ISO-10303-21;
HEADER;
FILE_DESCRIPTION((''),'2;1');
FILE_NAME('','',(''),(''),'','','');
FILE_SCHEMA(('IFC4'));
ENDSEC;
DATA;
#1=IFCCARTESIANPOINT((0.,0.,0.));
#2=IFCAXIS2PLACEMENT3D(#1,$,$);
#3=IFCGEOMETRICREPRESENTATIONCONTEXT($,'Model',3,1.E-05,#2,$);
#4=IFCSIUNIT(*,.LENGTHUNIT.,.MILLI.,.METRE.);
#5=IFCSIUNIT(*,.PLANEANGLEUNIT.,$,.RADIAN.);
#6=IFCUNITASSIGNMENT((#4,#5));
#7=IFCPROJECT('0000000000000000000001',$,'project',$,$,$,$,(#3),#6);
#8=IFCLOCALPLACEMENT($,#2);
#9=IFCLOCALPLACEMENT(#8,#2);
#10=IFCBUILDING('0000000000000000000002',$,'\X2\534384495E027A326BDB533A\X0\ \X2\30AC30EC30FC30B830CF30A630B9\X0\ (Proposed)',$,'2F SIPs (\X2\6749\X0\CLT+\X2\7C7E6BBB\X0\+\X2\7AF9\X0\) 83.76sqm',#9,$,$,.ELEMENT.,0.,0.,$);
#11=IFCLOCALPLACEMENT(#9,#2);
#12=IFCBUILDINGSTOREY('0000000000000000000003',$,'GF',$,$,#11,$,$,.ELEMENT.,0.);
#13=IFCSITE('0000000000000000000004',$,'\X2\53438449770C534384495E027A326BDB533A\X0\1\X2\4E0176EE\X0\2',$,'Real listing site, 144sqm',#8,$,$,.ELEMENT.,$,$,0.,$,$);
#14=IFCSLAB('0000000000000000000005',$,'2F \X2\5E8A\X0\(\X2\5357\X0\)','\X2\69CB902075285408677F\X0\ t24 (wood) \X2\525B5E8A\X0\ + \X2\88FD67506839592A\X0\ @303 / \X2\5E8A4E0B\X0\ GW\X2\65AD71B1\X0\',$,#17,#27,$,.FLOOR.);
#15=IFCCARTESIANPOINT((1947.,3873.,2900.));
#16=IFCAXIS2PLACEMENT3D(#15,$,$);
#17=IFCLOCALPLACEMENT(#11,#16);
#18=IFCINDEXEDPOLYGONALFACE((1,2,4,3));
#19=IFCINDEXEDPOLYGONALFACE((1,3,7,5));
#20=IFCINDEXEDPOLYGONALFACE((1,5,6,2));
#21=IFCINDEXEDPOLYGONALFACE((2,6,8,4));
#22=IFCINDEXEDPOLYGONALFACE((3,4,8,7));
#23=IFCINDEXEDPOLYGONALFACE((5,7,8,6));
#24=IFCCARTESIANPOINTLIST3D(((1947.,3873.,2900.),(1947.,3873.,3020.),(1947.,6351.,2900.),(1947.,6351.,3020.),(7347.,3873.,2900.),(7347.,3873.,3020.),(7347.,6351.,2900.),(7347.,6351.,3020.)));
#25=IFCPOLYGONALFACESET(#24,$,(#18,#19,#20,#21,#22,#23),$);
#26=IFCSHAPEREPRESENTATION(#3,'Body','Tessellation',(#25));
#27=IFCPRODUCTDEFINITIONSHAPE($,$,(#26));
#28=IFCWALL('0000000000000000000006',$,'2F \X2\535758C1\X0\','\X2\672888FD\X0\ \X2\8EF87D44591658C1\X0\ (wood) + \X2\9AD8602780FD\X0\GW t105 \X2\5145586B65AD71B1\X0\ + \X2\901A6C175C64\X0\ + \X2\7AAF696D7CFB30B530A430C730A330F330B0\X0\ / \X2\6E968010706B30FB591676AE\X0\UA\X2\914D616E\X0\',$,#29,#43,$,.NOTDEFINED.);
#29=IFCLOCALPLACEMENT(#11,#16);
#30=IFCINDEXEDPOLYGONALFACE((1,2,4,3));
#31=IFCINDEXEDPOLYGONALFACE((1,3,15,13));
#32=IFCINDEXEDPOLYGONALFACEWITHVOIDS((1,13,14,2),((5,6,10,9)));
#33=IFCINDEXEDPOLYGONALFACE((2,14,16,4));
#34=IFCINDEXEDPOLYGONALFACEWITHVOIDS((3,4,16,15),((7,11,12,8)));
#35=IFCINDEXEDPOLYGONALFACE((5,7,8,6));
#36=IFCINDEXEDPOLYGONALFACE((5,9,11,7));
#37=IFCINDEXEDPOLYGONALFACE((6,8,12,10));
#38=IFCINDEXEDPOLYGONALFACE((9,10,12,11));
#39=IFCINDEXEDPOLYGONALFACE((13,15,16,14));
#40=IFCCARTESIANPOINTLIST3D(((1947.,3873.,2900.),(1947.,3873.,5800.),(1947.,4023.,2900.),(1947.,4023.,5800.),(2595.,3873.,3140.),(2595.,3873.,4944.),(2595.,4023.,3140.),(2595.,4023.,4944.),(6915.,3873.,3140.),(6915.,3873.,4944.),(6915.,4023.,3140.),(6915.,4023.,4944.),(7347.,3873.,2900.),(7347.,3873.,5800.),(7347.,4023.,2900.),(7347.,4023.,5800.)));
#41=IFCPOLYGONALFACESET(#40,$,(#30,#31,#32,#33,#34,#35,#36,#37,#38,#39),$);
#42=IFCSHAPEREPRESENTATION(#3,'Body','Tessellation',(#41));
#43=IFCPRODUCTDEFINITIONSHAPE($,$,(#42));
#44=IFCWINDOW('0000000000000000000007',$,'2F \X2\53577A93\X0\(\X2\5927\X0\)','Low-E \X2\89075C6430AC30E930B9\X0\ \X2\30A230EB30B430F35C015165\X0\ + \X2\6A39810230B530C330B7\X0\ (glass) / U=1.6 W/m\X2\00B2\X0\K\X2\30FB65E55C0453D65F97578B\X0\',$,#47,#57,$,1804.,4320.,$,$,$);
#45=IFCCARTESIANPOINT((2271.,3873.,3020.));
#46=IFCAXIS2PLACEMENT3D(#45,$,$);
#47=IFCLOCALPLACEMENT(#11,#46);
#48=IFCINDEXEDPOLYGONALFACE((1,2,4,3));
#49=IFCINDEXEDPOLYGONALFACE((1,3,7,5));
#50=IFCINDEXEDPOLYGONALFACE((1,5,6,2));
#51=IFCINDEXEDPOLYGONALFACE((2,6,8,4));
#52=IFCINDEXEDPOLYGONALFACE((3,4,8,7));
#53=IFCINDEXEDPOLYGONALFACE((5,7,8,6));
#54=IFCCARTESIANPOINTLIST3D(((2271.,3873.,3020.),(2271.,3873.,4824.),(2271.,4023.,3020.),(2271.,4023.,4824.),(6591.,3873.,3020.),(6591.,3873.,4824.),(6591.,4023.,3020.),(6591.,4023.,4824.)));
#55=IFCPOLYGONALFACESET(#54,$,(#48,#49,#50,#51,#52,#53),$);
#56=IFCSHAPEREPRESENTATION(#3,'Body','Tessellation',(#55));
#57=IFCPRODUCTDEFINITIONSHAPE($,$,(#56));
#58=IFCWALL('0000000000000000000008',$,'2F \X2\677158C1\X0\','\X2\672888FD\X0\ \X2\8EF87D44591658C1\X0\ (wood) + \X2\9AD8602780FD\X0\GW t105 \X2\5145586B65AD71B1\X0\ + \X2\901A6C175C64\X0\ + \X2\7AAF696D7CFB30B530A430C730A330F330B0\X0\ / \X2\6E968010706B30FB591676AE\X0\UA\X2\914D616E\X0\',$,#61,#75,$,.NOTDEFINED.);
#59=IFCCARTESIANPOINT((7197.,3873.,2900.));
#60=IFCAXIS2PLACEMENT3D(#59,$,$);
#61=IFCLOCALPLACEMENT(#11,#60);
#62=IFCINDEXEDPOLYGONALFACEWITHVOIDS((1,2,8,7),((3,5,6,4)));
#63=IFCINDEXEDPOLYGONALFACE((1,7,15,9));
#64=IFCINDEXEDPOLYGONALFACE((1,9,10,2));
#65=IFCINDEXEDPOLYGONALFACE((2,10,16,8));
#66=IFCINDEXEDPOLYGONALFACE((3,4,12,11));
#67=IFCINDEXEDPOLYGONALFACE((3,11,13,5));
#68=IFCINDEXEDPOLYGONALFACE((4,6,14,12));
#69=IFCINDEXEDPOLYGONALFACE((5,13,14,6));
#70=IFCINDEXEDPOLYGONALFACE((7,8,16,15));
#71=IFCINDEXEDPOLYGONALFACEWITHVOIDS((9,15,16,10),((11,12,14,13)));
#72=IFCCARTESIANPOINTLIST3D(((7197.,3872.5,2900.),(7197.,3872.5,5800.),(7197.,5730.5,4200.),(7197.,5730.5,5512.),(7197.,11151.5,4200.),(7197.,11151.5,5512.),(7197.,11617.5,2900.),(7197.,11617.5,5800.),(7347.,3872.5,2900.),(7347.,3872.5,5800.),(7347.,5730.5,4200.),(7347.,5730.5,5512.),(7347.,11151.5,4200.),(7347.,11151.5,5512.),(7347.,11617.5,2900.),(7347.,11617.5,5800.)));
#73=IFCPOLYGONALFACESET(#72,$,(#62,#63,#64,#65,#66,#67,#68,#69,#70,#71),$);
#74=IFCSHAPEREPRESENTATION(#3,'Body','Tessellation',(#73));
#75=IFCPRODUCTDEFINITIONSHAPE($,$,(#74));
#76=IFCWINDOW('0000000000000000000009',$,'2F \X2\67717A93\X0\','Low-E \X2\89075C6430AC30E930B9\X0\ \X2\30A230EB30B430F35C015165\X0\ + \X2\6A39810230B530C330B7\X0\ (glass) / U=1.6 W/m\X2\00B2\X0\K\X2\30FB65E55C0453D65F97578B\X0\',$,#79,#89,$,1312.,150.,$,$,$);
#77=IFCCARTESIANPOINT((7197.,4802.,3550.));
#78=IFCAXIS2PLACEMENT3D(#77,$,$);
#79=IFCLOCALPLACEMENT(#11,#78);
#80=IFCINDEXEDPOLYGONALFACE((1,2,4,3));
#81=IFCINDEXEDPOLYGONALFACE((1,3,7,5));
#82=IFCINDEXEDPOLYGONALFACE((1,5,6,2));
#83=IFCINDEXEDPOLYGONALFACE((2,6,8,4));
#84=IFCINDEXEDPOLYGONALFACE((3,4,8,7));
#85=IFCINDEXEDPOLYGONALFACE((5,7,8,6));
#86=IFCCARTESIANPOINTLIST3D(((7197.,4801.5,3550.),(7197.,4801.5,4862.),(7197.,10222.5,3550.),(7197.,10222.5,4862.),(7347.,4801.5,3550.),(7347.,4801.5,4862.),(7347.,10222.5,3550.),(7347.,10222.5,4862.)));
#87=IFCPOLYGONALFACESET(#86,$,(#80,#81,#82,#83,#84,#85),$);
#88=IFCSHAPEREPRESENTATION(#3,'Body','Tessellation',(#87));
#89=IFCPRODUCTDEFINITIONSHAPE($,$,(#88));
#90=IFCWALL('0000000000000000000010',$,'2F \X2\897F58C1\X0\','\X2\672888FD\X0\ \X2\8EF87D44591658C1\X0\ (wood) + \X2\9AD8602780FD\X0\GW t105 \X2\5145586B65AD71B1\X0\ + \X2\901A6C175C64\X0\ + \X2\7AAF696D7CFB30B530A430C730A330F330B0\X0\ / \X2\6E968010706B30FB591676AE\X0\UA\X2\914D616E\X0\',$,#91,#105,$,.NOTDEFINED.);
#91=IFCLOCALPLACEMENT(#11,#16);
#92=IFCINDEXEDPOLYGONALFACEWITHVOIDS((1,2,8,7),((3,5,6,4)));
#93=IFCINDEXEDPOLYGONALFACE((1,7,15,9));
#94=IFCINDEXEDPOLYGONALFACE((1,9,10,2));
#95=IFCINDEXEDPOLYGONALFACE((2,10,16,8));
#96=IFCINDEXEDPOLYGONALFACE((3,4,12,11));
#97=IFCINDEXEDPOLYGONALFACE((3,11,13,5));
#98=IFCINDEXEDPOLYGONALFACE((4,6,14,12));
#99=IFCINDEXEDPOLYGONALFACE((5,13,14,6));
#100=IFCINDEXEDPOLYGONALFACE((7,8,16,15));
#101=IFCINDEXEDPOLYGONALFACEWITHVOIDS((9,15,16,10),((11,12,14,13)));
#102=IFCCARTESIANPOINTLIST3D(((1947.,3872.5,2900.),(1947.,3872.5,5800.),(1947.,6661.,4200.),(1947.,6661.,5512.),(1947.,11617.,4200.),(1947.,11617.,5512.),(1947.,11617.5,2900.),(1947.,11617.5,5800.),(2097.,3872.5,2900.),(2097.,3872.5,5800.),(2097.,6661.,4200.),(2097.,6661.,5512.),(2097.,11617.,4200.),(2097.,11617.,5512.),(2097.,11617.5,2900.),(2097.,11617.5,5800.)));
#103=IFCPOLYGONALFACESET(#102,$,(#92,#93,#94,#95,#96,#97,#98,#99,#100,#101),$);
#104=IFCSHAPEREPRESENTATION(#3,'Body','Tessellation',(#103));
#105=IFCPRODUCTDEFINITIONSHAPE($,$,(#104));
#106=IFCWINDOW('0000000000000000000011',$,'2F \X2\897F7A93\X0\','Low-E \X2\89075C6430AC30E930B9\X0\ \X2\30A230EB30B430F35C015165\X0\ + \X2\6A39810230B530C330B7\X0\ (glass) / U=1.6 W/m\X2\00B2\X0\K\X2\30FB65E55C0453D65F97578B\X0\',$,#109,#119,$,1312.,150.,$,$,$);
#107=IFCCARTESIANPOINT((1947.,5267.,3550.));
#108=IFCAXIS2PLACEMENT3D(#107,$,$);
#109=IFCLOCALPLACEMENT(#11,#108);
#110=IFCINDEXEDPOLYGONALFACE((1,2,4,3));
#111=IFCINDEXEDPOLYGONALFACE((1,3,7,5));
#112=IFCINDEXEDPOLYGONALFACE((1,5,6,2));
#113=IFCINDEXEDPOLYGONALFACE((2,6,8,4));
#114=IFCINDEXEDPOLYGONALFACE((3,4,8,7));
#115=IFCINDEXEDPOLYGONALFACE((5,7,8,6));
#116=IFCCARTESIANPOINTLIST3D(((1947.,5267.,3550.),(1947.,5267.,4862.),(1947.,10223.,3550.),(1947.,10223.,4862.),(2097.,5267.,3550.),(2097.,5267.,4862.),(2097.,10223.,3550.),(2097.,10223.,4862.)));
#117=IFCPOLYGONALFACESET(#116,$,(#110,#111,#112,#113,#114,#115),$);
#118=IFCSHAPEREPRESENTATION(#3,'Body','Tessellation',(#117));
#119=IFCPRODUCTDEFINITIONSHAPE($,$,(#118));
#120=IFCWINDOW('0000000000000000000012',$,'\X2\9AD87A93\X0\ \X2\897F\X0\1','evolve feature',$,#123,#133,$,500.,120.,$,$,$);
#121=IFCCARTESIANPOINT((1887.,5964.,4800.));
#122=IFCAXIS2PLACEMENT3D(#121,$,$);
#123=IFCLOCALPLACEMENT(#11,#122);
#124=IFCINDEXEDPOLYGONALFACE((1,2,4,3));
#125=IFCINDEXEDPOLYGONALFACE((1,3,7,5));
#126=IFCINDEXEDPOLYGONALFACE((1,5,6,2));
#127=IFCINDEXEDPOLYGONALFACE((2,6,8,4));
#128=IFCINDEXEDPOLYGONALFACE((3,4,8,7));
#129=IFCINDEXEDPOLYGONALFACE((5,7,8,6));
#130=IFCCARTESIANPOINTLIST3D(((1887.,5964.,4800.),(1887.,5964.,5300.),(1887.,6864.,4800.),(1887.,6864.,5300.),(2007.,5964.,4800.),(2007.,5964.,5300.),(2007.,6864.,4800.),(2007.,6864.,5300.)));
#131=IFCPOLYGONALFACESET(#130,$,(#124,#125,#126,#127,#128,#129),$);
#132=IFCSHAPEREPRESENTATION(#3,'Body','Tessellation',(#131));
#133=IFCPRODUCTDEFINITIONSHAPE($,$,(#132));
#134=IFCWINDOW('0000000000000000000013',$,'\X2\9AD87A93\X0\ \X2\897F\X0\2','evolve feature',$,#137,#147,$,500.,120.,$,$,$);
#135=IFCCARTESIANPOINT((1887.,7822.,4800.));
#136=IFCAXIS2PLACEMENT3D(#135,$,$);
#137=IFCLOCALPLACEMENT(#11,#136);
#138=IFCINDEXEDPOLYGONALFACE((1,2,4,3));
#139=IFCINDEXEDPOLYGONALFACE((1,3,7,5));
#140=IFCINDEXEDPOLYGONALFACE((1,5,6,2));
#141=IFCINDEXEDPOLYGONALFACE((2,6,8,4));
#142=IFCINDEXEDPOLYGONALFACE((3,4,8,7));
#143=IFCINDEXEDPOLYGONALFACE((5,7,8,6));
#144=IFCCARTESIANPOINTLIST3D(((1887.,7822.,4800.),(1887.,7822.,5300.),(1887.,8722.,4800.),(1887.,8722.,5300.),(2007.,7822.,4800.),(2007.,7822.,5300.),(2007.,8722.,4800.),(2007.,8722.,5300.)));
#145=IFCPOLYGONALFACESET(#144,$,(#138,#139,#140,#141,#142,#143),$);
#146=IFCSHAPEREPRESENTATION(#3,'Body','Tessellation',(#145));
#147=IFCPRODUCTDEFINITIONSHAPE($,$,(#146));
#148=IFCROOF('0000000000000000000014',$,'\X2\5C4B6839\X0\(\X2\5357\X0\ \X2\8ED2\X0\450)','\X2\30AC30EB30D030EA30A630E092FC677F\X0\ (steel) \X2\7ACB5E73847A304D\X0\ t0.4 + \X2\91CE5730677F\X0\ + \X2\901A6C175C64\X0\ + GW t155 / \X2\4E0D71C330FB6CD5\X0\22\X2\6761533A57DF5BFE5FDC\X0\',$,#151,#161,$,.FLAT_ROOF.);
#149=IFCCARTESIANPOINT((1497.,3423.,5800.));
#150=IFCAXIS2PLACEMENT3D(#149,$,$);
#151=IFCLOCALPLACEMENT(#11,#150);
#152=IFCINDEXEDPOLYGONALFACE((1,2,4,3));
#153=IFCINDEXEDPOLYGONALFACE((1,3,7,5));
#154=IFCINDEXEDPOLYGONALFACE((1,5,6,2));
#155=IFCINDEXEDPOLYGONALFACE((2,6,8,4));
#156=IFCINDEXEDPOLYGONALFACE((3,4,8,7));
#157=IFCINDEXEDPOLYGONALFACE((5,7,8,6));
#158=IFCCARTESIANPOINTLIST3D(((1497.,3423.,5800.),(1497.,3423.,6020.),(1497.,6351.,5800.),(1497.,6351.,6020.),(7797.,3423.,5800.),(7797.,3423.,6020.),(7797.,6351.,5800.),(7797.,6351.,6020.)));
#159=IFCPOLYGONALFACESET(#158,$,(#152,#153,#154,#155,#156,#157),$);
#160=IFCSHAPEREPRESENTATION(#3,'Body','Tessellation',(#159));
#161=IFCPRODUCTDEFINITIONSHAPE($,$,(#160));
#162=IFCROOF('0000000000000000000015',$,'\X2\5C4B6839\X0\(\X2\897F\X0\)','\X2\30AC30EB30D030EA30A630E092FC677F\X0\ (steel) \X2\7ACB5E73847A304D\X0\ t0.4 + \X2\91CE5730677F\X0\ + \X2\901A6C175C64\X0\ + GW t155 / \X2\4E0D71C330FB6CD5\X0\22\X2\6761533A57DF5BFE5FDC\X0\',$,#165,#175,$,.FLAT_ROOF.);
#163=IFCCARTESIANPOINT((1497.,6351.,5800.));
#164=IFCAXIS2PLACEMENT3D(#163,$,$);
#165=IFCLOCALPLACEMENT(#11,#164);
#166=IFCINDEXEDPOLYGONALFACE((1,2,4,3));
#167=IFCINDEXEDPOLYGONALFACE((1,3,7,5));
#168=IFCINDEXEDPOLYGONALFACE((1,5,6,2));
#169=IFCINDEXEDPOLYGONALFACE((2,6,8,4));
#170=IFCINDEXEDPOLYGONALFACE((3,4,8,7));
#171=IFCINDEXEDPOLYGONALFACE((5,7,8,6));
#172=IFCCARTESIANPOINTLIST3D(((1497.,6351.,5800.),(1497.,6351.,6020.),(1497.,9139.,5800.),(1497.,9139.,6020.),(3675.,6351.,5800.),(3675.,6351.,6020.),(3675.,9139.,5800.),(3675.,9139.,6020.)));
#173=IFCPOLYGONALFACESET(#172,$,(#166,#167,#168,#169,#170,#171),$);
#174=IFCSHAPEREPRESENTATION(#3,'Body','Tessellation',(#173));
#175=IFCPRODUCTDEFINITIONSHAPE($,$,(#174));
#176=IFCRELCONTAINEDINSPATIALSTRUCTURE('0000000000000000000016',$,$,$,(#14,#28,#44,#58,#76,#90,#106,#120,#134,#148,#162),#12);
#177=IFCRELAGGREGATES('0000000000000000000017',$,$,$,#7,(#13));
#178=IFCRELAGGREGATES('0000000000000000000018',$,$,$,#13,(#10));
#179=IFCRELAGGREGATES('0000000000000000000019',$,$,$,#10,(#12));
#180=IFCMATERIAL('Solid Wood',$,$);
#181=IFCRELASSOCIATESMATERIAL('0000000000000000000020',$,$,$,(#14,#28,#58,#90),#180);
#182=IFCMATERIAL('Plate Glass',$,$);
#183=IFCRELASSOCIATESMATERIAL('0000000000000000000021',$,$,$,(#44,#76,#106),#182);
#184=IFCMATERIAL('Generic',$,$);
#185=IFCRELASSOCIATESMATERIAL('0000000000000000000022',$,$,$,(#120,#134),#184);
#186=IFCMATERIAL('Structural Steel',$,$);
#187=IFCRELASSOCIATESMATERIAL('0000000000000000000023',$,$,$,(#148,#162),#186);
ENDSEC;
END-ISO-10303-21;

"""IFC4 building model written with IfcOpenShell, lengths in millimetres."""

from ifc_helpers import new_model, si_unit, frame, frame_2d, origin, place, context, project, spatial, rectangle, extrude, material, element, fill, save


model = new_model("IFC4")

# Units and contexts
model_context = context("Model", 3, precision=1e-05, world=origin())
ifc_project = project(units=[si_unit("LENGTHUNIT", "METRE", prefix="MILLI"), si_unit("PLANEANGLEUNIT", "RADIAN")], contexts=[model_context])

# Site, building, storey
site_placement = place(None, origin())
site = spatial("IfcSite", under=ifc_project, at=site_placement, Name="千葉県千葉市稲毛区1丁目2", ObjectType="Real listing site, 144sqm", CompositionType="ELEMENT", RefElevation=0.0)
building_placement = place(site_placement, origin())
building = spatial("IfcBuilding", under=site, at=building_placement, Name="千葉市稲毛区 ガレージハウス (Proposed)", ObjectType="2F SIPs (杉CLT+籾殻+竹) 83.76sqm", CompositionType="ELEMENT", ElevationOfRefHeight=0.0, ElevationOfTerrain=0.0)
storey_placement = place(building_placement, origin())
storey = spatial("IfcBuildingStorey", under=building, at=storey_placement, Name="GF", CompositionType="ELEMENT", Elevation=0.0)

# Slab
ifc_material_1 = material(Name="Solid Wood")
slab_placement = place(storey_placement, frame((1947.0, 3873.0, 2900.0)))
element("IfcSlab", 1, at=slab_placement, inside=storey, material=ifc_material_1, Name="2F 床(南)", Description="構造用合板 t24 (wood) 剛床 + 製材根太 @303 / 床下 GW断熱", PredefinedType="FLOOR", context=model_context, shape_type="SweptSolid", body=[
    extrude(rectangle(XDim=5400.0, YDim=2478.0, at=frame_2d((2700.0, 1239.0))), frame((1947.0, 3873.0, 2900.0)), (0.0, 0.0, 1.0), 120.0),
])

# Walls, openings, windows
wall_1_placement = place(storey_placement, frame((1947.0, 3873.0, 2900.0)))
wall_1 = element("IfcWall", 2, at=wall_1_placement, inside=storey, material=ifc_material_1, Name="2F 南壁", Description="木製 軸組外壁 (wood) + 高性能GW t105 充填断熱 + 通気層 + 窯業系サイディング / 準耐火・外皮UA配慮", PredefinedType="NOTDEFINED", context=model_context, shape_type="SweptSolid", body=[
    extrude(rectangle(XDim=5400.0, YDim=150.0, at=frame_2d((2700.0, 75.0))), frame((1947.0, 3873.0, 2900.0)), (0.0, 0.0, 1.0), 2900.0),
])
opening_1_placement = place(storey_placement, frame((2271.0, 3873.0, 3020.0)))
opening_1 = element("IfcOpeningElement", 3, at=opening_1_placement, cuts=wall_1, PredefinedType="NOTDEFINED", context=model_context, shape_type="SweptSolid", body=[
    extrude(rectangle(XDim=4320.0, YDim=150.0, at=frame_2d((2160.0, 75.0))), frame((2271.0, 3873.0, 3020.0)), (0.0, 0.0, 1.0), 1804.0),
])
ifc_material_2 = material(Name="Plate Glass")
window_1_placement = place(storey_placement, frame((2271.0, 3873.0, 3020.0)))
window_1 = element("IfcWindow", 4, at=window_1_placement, inside=storey, material=ifc_material_2, Name="2F 南窓(大)", Description="Low-E 複層ガラス アルゴン封入 + 樹脂サッシ (glass) / U=1.6 W/m²K・日射取得型", OverallHeight=1804.0, OverallWidth=4320.0, context=model_context, shape_type="SweptSolid", body=[
    extrude(rectangle(XDim=4320.0, YDim=150.0, at=frame_2d((2160.0, 75.0))), frame((2271.0, 3873.0, 3020.0)), (0.0, 0.0, 1.0), 1804.0),
])
fill(opening_1, window_1)
wall_2_placement = place(storey_placement, frame((7197.0, 3873.0, 2900.0)))
wall_2 = element("IfcWall", 5, at=wall_2_placement, inside=storey, material=ifc_material_1, Name="2F 東壁", Description="木製 軸組外壁 (wood) + 高性能GW t105 充填断熱 + 通気層 + 窯業系サイディング / 準耐火・外皮UA配慮", PredefinedType="NOTDEFINED", context=model_context, shape_type="SweptSolid", body=[
    extrude(rectangle(XDim=150.0, YDim=7745.0, at=frame_2d((75.0, 3872.0))), frame((7197.0, 3873.0, 2900.0)), (0.0, 0.0, 1.0), 2900.0),
])
opening_2_placement = place(storey_placement, frame((7197.0, 4802.0, 3550.0)))
opening_2 = element("IfcOpeningElement", 6, at=opening_2_placement, cuts=wall_2, PredefinedType="NOTDEFINED", context=model_context, shape_type="SweptSolid", body=[
    extrude(rectangle(XDim=150.0, YDim=5421.0, at=frame_2d((75.0, 2710.0))), frame((7197.0, 4802.0, 3550.0)), (0.0, 0.0, 1.0), 1312.0),
])
window_2_placement = place(storey_placement, frame((7197.0, 4802.0, 3550.0)))
window_2 = element("IfcWindow", 7, at=window_2_placement, inside=storey, material=ifc_material_2, Name="2F 東窓", Description="Low-E 複層ガラス アルゴン封入 + 樹脂サッシ (glass) / U=1.6 W/m²K・日射取得型", OverallHeight=1312.0, OverallWidth=150.0, context=model_context, shape_type="SweptSolid", body=[
    extrude(rectangle(XDim=150.0, YDim=5421.0, at=frame_2d((75.0, 2710.0))), frame((7197.0, 4802.0, 3550.0)), (0.0, 0.0, 1.0), 1312.0),
])
fill(opening_2, window_2)

# Wall, openings, windows
wall_3_placement = place(storey_placement, frame((1947.0, 3873.0, 2900.0)))
wall_3 = element("IfcWall", 8, at=wall_3_placement, inside=storey, material=ifc_material_1, Name="2F 西壁", Description="木製 軸組外壁 (wood) + 高性能GW t105 充填断熱 + 通気層 + 窯業系サイディング / 準耐火・外皮UA配慮", PredefinedType="NOTDEFINED", context=model_context, shape_type="SweptSolid", body=[
    extrude(rectangle(XDim=150.0, YDim=7745.0, at=frame_2d((75.0, 3872.0))), frame((1947.0, 3873.0, 2900.0)), (0.0, 0.0, 1.0), 2900.0),
])
opening_3_placement = place(storey_placement, frame((1947.0, 5267.0, 3550.0)))
opening_3 = element("IfcOpeningElement", 9, at=opening_3_placement, cuts=wall_3, PredefinedType="NOTDEFINED", context=model_context, shape_type="SweptSolid", body=[
    extrude(rectangle(XDim=150.0, YDim=4956.0, at=frame_2d((75.0, 2478.0))), frame((1947.0, 5267.0, 3550.0)), (0.0, 0.0, 1.0), 1312.0),
])
opening_4_placement = place(storey_placement, frame((1887.0, 5964.0, 4800.0)))
opening_4 = element("IfcOpeningElement", 10, at=opening_4_placement, cuts=wall_3, PredefinedType="NOTDEFINED", context=model_context, shape_type="SweptSolid", body=[
    extrude(rectangle(XDim=120.0, YDim=900.0, at=frame_2d((60.0, 450.0))), frame((1887.0, 5964.0, 4800.0)), (0.0, 0.0, 1.0), 500.0),
])
opening_5_placement = place(storey_placement, frame((1887.0, 7822.0, 4800.0)))
opening_5 = element("IfcOpeningElement", 11, at=opening_5_placement, cuts=wall_3, PredefinedType="NOTDEFINED", context=model_context, shape_type="SweptSolid", body=[
    extrude(rectangle(XDim=120.0, YDim=900.0, at=frame_2d((60.0, 450.0))), frame((1887.0, 7822.0, 4800.0)), (0.0, 0.0, 1.0), 500.0),
])
window_3_placement = place(storey_placement, frame((1947.0, 5267.0, 3550.0)))
window_3 = element("IfcWindow", 12, at=window_3_placement, inside=storey, material=ifc_material_2, Name="2F 西窓", Description="Low-E 複層ガラス アルゴン封入 + 樹脂サッシ (glass) / U=1.6 W/m²K・日射取得型", OverallHeight=1312.0, OverallWidth=150.0, context=model_context, shape_type="SweptSolid", body=[
    extrude(rectangle(XDim=150.0, YDim=4956.0, at=frame_2d((75.0, 2478.0))), frame((1947.0, 5267.0, 3550.0)), (0.0, 0.0, 1.0), 1312.0),
])
fill(opening_3, window_3)
ifc_material_3 = material(Name="Generic")
window_4_placement = place(storey_placement, frame((1887.0, 5964.0, 4800.0)))
window_4 = element("IfcWindow", 13, at=window_4_placement, inside=storey, material=ifc_material_3, Name="高窓 西1", Description="evolve feature", OverallHeight=500.0, OverallWidth=120.0, context=model_context, shape_type="SweptSolid", body=[
    extrude(rectangle(XDim=120.0, YDim=900.0, at=frame_2d((60.0, 450.0))), frame((1887.0, 5964.0, 4800.0)), (0.0, 0.0, 1.0), 500.0),
])
fill(opening_4, window_4)
window_5_placement = place(storey_placement, frame((1887.0, 7822.0, 4800.0)))
window_5 = element("IfcWindow", 14, at=window_5_placement, inside=storey, material=ifc_material_3, Name="高窓 西2", Description="evolve feature", OverallHeight=500.0, OverallWidth=120.0, context=model_context, shape_type="SweptSolid", body=[
    extrude(rectangle(XDim=120.0, YDim=900.0, at=frame_2d((60.0, 450.0))), frame((1887.0, 7822.0, 4800.0)), (0.0, 0.0, 1.0), 500.0),
])
fill(opening_5, window_5)

# Roofs
ifc_material_4 = material(Name="Structural Steel")
roof_1_placement = place(storey_placement, frame((1497.0, 3423.0, 5800.0)))
element("IfcRoof", 15, at=roof_1_placement, inside=storey, material=ifc_material_4, Name="屋根(南 軒450)", Description="ガルバリウム鋼板 (steel) 立平葺き t0.4 + 野地板 + 通気層 + GW t155 / 不燃・法22条区域対応", PredefinedType="FLAT_ROOF", context=model_context, shape_type="SweptSolid", body=[
    extrude(rectangle(XDim=6300.0, YDim=2928.0, at=frame_2d((3150.0, 1464.0))), frame((1497.0, 3423.0, 5800.0)), (0.0, 0.0, 1.0), 220.0),
])
roof_2_placement = place(storey_placement, frame((1497.0, 6351.0, 5800.0)))
element("IfcRoof", 16, at=roof_2_placement, inside=storey, material=ifc_material_4, Name="屋根(西)", Description="ガルバリウム鋼板 (steel) 立平葺き t0.4 + 野地板 + 通気層 + GW t155 / 不燃・法22条区域対応", PredefinedType="FLAT_ROOF", context=model_context, shape_type="SweptSolid", body=[
    extrude(rectangle(XDim=2178.0, YDim=2788.0, at=frame_2d((1089.0, 1394.0))), frame((1497.0, 6351.0, 5800.0)), (0.0, 0.0, 1.0), 220.0),
])

save(model, "model.ifc")
